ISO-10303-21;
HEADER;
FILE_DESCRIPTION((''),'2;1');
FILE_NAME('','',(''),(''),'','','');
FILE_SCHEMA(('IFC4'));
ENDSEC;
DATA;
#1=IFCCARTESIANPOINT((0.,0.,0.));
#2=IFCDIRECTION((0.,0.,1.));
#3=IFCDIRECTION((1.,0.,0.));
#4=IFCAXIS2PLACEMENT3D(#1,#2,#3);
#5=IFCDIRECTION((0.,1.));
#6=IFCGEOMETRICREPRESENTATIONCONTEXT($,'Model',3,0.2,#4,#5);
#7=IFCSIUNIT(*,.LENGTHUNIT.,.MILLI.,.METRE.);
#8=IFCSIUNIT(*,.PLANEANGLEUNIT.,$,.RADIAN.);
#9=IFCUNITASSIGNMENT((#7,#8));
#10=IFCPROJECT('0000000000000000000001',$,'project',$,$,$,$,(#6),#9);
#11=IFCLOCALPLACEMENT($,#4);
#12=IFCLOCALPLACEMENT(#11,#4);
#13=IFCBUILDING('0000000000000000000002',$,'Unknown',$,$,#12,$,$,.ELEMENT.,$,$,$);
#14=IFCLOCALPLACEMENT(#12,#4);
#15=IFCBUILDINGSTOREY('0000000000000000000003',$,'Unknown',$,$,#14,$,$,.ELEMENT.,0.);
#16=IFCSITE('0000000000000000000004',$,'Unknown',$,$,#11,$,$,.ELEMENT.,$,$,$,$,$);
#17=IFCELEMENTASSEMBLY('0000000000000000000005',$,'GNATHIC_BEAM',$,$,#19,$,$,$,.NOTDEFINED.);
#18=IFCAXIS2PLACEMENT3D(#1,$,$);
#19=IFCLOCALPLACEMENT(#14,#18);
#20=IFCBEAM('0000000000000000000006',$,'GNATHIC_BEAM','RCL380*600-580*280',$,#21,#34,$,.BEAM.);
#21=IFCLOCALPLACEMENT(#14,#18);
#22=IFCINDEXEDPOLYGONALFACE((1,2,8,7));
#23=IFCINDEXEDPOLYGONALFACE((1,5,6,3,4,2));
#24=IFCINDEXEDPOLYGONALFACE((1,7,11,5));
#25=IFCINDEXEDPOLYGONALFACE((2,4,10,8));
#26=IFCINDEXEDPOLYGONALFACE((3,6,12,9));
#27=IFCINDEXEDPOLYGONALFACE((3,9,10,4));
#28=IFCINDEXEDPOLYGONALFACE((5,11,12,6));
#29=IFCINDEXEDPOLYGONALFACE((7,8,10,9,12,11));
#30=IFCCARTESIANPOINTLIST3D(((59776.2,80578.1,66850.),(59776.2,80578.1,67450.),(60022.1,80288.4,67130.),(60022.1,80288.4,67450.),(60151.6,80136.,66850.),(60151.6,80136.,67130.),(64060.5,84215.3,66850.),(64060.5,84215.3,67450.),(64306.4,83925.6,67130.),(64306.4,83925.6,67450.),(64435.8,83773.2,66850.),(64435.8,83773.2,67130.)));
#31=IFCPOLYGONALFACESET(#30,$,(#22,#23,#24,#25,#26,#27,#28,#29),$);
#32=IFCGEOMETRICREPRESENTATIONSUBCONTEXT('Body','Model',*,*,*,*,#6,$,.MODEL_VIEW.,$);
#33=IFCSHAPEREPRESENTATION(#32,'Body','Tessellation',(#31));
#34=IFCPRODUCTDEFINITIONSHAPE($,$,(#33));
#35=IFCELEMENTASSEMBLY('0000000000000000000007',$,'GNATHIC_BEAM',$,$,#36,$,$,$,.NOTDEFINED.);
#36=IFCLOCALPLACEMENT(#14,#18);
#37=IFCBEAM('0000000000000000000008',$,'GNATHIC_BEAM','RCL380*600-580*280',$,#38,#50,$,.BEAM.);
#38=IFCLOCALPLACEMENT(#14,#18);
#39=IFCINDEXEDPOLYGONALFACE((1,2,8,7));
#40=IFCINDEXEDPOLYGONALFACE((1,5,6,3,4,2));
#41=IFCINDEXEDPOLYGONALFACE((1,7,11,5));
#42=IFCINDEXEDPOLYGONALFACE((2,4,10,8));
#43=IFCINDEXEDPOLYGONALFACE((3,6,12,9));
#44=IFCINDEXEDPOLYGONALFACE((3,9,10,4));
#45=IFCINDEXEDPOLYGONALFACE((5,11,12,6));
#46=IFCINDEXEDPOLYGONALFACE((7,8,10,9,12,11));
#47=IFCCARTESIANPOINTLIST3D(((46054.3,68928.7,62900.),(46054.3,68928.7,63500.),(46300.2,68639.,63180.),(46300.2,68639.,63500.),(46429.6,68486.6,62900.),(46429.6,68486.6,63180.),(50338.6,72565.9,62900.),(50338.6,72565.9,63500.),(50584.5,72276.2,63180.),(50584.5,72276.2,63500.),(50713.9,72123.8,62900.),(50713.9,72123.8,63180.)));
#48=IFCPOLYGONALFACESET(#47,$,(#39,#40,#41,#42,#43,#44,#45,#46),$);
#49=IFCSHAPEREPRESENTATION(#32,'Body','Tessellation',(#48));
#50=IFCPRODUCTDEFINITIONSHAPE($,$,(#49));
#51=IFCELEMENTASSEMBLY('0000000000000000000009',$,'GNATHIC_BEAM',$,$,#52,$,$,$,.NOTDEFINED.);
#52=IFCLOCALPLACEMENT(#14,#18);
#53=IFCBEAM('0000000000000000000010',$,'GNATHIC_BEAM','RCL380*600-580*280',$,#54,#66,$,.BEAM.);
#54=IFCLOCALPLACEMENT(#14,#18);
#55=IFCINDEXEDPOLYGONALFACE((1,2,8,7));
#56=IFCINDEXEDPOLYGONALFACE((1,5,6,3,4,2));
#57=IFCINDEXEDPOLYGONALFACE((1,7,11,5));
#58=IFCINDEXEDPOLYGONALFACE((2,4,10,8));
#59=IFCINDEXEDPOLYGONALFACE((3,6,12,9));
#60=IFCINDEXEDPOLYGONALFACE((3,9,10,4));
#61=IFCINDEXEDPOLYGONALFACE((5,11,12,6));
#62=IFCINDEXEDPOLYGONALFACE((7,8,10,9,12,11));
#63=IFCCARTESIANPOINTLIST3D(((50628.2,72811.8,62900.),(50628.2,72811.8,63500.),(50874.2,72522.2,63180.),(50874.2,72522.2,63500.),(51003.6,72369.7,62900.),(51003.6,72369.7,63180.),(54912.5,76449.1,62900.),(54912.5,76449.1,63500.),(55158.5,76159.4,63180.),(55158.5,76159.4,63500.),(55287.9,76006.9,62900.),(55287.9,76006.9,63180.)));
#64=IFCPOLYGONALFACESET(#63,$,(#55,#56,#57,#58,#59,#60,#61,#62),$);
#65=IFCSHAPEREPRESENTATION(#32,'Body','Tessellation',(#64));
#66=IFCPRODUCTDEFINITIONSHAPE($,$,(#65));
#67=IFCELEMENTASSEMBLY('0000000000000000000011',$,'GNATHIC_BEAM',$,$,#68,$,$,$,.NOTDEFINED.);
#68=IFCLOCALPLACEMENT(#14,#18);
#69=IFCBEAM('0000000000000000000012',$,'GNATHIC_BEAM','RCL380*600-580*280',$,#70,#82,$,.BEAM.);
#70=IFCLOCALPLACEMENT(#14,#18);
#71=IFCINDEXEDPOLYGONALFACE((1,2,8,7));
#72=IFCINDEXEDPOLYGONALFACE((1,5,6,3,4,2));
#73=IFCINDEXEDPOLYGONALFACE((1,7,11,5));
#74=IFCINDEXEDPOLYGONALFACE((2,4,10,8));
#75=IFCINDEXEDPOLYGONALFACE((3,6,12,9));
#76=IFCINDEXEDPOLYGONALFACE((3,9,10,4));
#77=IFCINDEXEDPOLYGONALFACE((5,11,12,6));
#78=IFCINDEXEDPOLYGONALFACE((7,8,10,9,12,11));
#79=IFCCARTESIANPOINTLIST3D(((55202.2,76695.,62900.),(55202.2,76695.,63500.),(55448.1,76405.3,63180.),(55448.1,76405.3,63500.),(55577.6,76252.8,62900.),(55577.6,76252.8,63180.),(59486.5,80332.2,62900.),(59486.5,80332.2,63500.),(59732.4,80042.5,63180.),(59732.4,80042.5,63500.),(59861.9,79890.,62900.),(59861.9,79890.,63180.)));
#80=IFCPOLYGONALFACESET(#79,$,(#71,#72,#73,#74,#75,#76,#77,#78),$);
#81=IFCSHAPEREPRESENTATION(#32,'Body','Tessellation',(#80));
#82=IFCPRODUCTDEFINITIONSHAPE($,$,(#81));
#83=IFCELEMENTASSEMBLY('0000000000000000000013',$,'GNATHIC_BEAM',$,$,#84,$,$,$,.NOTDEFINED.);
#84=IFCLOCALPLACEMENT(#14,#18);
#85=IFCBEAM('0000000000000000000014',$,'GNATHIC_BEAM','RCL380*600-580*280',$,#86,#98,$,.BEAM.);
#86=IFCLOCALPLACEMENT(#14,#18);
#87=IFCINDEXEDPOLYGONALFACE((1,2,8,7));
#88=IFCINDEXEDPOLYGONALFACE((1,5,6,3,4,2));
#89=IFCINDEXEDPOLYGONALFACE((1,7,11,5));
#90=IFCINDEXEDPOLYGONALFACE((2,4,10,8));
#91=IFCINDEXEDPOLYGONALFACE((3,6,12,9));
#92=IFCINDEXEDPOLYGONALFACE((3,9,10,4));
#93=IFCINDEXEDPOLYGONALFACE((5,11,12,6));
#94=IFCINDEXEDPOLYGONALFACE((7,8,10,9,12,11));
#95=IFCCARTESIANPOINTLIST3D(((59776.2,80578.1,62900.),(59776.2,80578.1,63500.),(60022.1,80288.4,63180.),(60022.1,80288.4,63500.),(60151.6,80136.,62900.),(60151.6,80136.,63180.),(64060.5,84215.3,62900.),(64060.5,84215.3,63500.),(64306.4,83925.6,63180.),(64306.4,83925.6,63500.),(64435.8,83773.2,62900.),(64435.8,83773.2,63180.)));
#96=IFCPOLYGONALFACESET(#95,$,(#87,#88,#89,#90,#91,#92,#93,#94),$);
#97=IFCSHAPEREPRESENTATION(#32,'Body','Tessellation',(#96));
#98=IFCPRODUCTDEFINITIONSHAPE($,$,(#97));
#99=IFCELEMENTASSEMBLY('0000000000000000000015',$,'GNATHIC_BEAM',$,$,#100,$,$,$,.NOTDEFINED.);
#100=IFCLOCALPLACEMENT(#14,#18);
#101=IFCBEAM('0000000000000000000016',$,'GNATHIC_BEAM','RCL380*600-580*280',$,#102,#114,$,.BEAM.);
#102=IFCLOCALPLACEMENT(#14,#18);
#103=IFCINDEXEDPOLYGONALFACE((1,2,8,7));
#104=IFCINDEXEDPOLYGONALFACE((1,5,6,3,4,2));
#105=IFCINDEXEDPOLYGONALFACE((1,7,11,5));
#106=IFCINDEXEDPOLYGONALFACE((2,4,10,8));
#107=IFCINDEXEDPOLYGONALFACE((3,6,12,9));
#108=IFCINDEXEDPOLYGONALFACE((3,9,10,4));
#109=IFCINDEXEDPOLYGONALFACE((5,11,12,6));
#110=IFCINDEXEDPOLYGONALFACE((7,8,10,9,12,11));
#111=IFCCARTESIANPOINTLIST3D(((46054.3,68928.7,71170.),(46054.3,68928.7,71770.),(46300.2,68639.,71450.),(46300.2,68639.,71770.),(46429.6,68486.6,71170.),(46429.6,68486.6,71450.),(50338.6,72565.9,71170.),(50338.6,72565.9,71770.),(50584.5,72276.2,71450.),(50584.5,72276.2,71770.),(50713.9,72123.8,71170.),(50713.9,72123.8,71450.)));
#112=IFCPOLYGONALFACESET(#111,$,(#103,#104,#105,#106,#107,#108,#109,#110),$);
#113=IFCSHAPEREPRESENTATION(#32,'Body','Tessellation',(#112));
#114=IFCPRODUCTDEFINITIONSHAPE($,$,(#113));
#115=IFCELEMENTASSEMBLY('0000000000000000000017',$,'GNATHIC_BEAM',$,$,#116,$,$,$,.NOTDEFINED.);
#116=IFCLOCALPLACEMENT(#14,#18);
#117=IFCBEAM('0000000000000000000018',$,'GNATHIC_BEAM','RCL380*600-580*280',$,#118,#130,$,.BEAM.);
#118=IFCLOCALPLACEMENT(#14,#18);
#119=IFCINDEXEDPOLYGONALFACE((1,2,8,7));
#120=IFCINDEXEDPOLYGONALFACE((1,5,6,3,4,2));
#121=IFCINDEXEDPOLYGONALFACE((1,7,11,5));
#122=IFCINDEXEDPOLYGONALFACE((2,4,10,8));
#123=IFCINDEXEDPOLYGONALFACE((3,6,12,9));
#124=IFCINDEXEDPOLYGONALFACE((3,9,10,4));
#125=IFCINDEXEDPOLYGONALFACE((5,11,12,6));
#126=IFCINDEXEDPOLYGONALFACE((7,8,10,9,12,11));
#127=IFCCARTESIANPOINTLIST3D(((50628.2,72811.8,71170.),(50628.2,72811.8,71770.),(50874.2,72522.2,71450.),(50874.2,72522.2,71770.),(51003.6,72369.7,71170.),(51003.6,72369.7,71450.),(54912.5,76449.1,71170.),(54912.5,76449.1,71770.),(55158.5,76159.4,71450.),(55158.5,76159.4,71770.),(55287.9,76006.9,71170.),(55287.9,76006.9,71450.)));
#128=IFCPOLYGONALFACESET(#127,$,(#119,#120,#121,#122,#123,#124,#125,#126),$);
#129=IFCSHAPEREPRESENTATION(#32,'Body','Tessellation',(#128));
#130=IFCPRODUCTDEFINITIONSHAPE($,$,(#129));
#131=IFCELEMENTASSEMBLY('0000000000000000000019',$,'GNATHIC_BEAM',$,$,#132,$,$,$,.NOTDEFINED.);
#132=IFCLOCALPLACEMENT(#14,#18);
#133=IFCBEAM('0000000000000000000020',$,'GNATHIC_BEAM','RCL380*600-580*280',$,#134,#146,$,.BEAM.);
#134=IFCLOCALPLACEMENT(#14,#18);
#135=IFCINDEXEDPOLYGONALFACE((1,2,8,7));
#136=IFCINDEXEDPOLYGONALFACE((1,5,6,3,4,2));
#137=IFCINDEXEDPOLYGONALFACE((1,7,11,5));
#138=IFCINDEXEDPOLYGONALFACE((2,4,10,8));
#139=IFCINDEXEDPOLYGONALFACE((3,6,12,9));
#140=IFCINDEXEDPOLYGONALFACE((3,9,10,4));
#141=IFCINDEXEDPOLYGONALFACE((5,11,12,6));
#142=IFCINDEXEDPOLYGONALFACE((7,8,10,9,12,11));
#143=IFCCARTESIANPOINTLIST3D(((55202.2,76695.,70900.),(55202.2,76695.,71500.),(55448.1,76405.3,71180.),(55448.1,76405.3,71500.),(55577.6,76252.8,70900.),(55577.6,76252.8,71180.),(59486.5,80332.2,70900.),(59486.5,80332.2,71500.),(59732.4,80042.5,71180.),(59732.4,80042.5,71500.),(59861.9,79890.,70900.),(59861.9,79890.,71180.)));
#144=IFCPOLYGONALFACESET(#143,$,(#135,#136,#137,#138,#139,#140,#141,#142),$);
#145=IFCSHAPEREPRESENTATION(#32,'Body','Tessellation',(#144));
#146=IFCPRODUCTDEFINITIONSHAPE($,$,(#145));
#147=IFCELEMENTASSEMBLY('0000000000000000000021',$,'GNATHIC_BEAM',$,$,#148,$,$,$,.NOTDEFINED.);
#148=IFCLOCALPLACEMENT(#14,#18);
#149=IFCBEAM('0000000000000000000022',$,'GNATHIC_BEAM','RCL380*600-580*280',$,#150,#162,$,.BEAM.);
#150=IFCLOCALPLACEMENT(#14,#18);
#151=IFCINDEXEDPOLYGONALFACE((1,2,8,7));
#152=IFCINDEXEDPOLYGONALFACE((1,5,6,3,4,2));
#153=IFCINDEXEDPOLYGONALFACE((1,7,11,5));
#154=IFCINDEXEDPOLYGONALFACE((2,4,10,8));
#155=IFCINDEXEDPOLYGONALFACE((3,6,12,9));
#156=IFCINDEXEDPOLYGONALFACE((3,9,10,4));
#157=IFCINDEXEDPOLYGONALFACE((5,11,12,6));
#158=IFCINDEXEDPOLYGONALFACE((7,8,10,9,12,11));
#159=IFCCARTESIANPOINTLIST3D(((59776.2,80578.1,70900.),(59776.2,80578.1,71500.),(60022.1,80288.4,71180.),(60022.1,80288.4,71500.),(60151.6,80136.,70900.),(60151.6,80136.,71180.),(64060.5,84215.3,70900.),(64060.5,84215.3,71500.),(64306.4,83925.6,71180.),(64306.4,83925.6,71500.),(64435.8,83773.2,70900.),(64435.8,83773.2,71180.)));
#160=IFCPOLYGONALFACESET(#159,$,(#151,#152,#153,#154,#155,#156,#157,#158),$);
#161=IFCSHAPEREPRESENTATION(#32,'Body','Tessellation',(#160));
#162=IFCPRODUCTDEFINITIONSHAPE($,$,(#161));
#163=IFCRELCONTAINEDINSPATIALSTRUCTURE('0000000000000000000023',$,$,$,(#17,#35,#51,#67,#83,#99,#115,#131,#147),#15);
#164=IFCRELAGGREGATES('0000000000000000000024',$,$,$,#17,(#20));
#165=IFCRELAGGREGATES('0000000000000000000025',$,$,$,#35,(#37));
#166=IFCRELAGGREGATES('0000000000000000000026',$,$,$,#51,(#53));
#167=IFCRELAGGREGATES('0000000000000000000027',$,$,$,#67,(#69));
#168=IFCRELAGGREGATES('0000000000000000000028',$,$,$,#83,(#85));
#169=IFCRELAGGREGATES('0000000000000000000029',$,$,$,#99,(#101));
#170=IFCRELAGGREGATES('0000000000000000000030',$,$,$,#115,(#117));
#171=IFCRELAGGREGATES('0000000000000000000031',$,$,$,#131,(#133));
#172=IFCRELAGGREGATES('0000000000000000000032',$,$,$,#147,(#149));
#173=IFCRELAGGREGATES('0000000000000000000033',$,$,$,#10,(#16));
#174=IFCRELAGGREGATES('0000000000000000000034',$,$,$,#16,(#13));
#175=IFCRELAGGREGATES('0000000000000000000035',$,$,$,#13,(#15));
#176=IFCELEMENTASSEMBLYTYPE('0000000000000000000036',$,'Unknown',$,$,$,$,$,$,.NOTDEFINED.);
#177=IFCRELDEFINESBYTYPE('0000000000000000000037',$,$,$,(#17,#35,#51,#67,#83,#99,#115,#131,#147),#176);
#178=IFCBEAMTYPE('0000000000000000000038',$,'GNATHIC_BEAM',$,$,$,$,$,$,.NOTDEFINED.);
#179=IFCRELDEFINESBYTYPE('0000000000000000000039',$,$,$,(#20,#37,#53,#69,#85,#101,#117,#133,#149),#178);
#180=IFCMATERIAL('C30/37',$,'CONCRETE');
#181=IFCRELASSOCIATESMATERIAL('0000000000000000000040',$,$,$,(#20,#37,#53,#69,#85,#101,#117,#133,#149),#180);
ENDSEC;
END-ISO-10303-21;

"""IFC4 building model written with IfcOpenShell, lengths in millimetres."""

from ifc_helpers import new_model, si_unit, direction, frame, origin_with_axes, place, context, subcontext, project, spatial, polyline, outline, extrude, material, material_profile, profile_set, profile_usage, type_object, element, aggregate, save


model = new_model("IFC4")

# Units and contexts
model_context = context("Model", 3, precision=0.2, world=origin_with_axes(), true_north=direction((0.0, 1.0)))
body_context = subcontext(model_context, "Body", "Model", "MODEL_VIEW")
ifc_project = project(units=[si_unit("LENGTHUNIT", "METRE", prefix="MILLI"), si_unit("PLANEANGLEUNIT", "RADIAN")], contexts=[model_context])

# Site, building, storey
site_placement = place(None, origin_with_axes())
site = spatial("IfcSite", under=ifc_project, at=site_placement, Name="Unknown", CompositionType="ELEMENT")
building_placement = place(site_placement, origin_with_axes())
building = spatial("IfcBuilding", under=site, at=building_placement, Name="Unknown", CompositionType="ELEMENT")
storey_placement = place(building_placement, origin_with_axes())
storey = spatial("IfcBuildingStorey", under=building, at=storey_placement, Name="Unknown", CompositionType="ELEMENT", Elevation=0.0)

# Shared definitions
element_assembly_type = type_object("IfcElementAssemblyType", Name="Unknown", PredefinedType="NOTDEFINED")

# Element assemblies, beams
ifc_material_1 = material(Name="C30/37", Category="CONCRETE")
ifc_material_profile_1 = material_profile(ifc_material_1, outline(polyline([(-190.0, -300.0), (390.0, -300.0), (390.0, -20.0), (190.0, -20.0), (190.0, 300.0), (-190.0, 300.0), (-190.0, -300.0)])), Name="RCL380*600-580*280")
ifc_profile_set_1 = profile_set([ifc_material_profile_1])
ifc_profile_usage_1 = profile_usage(ifc_profile_set_1, cardinal=2)
beam_type_1 = type_object("IfcBeamType", Name="GNATHIC_BEAM")
assembly_1_placement = place(storey_placement, frame((59899.1, 80433.3, 67150.0), z_axis=(0.64719, -0.762329, 0.0), x_axis=(0.762329, 0.64719, 0.0)))
assembly_1 = element("IfcElementAssembly", 1, at=assembly_1_placement, inside=storey, type_object=element_assembly_type, Name="GNATHIC_BEAM", PredefinedType="NOTDEFINED")
beam_1_placement = place(assembly_1_placement, origin_with_axes())
beam_1 = element("IfcBeam", 2, at=beam_1_placement, type_object=beam_type_1, material=ifc_profile_usage_1, Name="GNATHIC_BEAM", Description="RCL380*600-580*280", PredefinedType="BEAM", context=body_context, shape_type="SolidModel", body=[
    extrude(outline(polyline([(-190.0, -300.0), (390.0, -300.0), (390.0, -20.0), (190.0, -20.0), (190.0, 300.0), (-190.0, 300.0), (-190.0, -300.0)])), frame((0.0, 0.0, 0.0), z_axis=(-1.0, 0.0, 0.0), x_axis=(0.0, 0.0, 1.0)), (0.0, 0.0, -1.0), 5620.0),
])
aggregate(assembly_1, [beam_1])
assembly_2_placement = place(storey_placement, frame((46177.2, 68783.9, 63200.0), z_axis=(0.64719, -0.762329, 0.0), x_axis=(0.762329, 0.64719, 0.0)))
assembly_2 = element("IfcElementAssembly", 3, at=assembly_2_placement, inside=storey, type_object=element_assembly_type, Name="GNATHIC_BEAM", PredefinedType="NOTDEFINED")
beam_2_placement = place(assembly_2_placement, origin_with_axes())
beam_2 = element("IfcBeam", 4, at=beam_2_placement, type_object=beam_type_1, material=ifc_profile_usage_1, Name="GNATHIC_BEAM", Description="RCL380*600-580*280", PredefinedType="BEAM", context=body_context, shape_type="SolidModel", body=[
    extrude(outline(polyline([(-190.0, -300.0), (390.0, -300.0), (390.0, -20.0), (190.0, -20.0), (190.0, 300.0), (-190.0, 300.0), (-190.0, -300.0)])), frame((0.0, 0.0, 0.0), z_axis=(-1.0, 0.0, 0.0), x_axis=(0.0, 0.0, 1.0)), (0.0, 0.0, -1.0), 5620.0),
])
aggregate(assembly_2, [beam_2])
assembly_3_placement = place(storey_placement, frame((50751.2, 72667.0, 63200.0), z_axis=(0.64719, -0.762329, 0.0), x_axis=(0.762329, 0.64719, 0.0)))
assembly_3 = element("IfcElementAssembly", 5, at=assembly_3_placement, inside=storey, type_object=element_assembly_type, Name="GNATHIC_BEAM", PredefinedType="NOTDEFINED")
beam_3_placement = place(assembly_3_placement, origin_with_axes())
beam_3 = element("IfcBeam", 6, at=beam_3_placement, type_object=beam_type_1, material=ifc_profile_usage_1, Name="GNATHIC_BEAM", Description="RCL380*600-580*280", PredefinedType="BEAM", context=body_context, shape_type="SolidModel", body=[
    extrude(outline(polyline([(-190.0, -300.0), (390.0, -300.0), (390.0, -20.0), (190.0, -20.0), (190.0, 300.0), (-190.0, 300.0), (-190.0, -300.0)])), frame((0.0, 0.0, 0.0), z_axis=(-1.0, 0.0, 0.0), x_axis=(0.0, 0.0, 1.0)), (0.0, 0.0, -1.0), 5620.0),
])
aggregate(assembly_3, [beam_3])
assembly_4_placement = place(storey_placement, frame((55325.2, 76550.1, 63200.0), z_axis=(0.64719, -0.762329, 0.0), x_axis=(0.762329, 0.64719, 0.0)))
assembly_4 = element("IfcElementAssembly", 7, at=assembly_4_placement, inside=storey, type_object=element_assembly_type, Name="GNATHIC_BEAM", PredefinedType="NOTDEFINED")
beam_4_placement = place(assembly_4_placement, origin_with_axes())
beam_4 = element("IfcBeam", 8, at=beam_4_placement, type_object=beam_type_1, material=ifc_profile_usage_1, Name="GNATHIC_BEAM", Description="RCL380*600-580*280", PredefinedType="BEAM", context=body_context, shape_type="SolidModel", body=[
    extrude(outline(polyline([(-190.0, -300.0), (390.0, -300.0), (390.0, -20.0), (190.0, -20.0), (190.0, 300.0), (-190.0, 300.0), (-190.0, -300.0)])), frame((0.0, 0.0, 0.0), z_axis=(-1.0, 0.0, 0.0), x_axis=(0.0, 0.0, 1.0)), (0.0, 0.0, -1.0), 5620.0),
])
aggregate(assembly_4, [beam_4])
assembly_5_placement = place(storey_placement, frame((59899.1, 80433.3, 63200.0), z_axis=(0.64719, -0.762329, 0.0), x_axis=(0.762329, 0.64719, 0.0)))
assembly_5 = element("IfcElementAssembly", 9, at=assembly_5_placement, inside=storey, type_object=element_assembly_type, Name="GNATHIC_BEAM", PredefinedType="NOTDEFINED")
beam_5_placement = place(assembly_5_placement, origin_with_axes())
beam_5 = element("IfcBeam", 10, at=beam_5_placement, type_object=beam_type_1, material=ifc_profile_usage_1, Name="GNATHIC_BEAM", Description="RCL380*600-580*280", PredefinedType="BEAM", context=body_context, shape_type="SolidModel", body=[
    extrude(outline(polyline([(-190.0, -300.0), (390.0, -300.0), (390.0, -20.0), (190.0, -20.0), (190.0, 300.0), (-190.0, 300.0), (-190.0, -300.0)])), frame((0.0, 0.0, 0.0), z_axis=(-1.0, 0.0, 0.0), x_axis=(0.0, 0.0, 1.0)), (0.0, 0.0, -1.0), 5620.0),
])
aggregate(assembly_5, [beam_5])
assembly_6_placement = place(storey_placement, frame((46177.2, 68783.9, 71470.0), z_axis=(0.64719, -0.762329, 0.0), x_axis=(0.762329, 0.64719, 0.0)))
assembly_6 = element("IfcElementAssembly", 11, at=assembly_6_placement, inside=storey, type_object=element_assembly_type, Name="GNATHIC_BEAM", PredefinedType="NOTDEFINED")
beam_6_placement = place(assembly_6_placement, origin_with_axes())
beam_6 = element("IfcBeam", 12, at=beam_6_placement, type_object=beam_type_1, material=ifc_profile_usage_1, Name="GNATHIC_BEAM", Description="RCL380*600-580*280", PredefinedType="BEAM", context=body_context, shape_type="SolidModel", body=[
    extrude(outline(polyline([(-190.0, -300.0), (390.0, -300.0), (390.0, -20.0), (190.0, -20.0), (190.0, 300.0), (-190.0, 300.0), (-190.0, -300.0)])), frame((0.0, 0.0, 0.0), z_axis=(-1.0, 0.0, 0.0), x_axis=(0.0, 0.0, 1.0)), (0.0, 0.0, -1.0), 5620.0),
])
aggregate(assembly_6, [beam_6])
assembly_7_placement = place(storey_placement, frame((50751.2, 72667.0, 71470.0), z_axis=(0.64719, -0.762329, 0.0), x_axis=(0.762329, 0.64719, 0.0)))
assembly_7 = element("IfcElementAssembly", 13, at=assembly_7_placement, inside=storey, type_object=element_assembly_type, Name="GNATHIC_BEAM", PredefinedType="NOTDEFINED")
beam_7_placement = place(assembly_7_placement, origin_with_axes())
beam_7 = element("IfcBeam", 14, at=beam_7_placement, type_object=beam_type_1, material=ifc_profile_usage_1, Name="GNATHIC_BEAM", Description="RCL380*600-580*280", PredefinedType="BEAM", context=body_context, shape_type="SolidModel", body=[
    extrude(outline(polyline([(-190.0, -300.0), (390.0, -300.0), (390.0, -20.0), (190.0, -20.0), (190.0, 300.0), (-190.0, 300.0), (-190.0, -300.0)])), frame((0.0, 0.0, 0.0), z_axis=(-1.0, 0.0, 0.0), x_axis=(0.0, 0.0, 1.0)), (0.0, 0.0, -1.0), 5620.0),
])
aggregate(assembly_7, [beam_7])
assembly_8_placement = place(storey_placement, frame((55325.2, 76550.1, 71200.0), z_axis=(0.64719, -0.762329, 0.0), x_axis=(0.762329, 0.64719, 0.0)))
assembly_8 = element("IfcElementAssembly", 15, at=assembly_8_placement, inside=storey, type_object=element_assembly_type, Name="GNATHIC_BEAM", PredefinedType="NOTDEFINED")
beam_8_placement = place(assembly_8_placement, origin_with_axes())
beam_8 = element("IfcBeam", 16, at=beam_8_placement, type_object=beam_type_1, material=ifc_profile_usage_1, Name="GNATHIC_BEAM", Description="RCL380*600-580*280", PredefinedType="BEAM", context=body_context, shape_type="SolidModel", body=[
    extrude(outline(polyline([(-190.0, -300.0), (390.0, -300.0), (390.0, -20.0), (190.0, -20.0), (190.0, 300.0), (-190.0, 300.0), (-190.0, -300.0)])), frame((0.0, 0.0, 0.0), z_axis=(-1.0, 0.0, 0.0), x_axis=(0.0, 0.0, 1.0)), (0.0, 0.0, -1.0), 5620.0),
])
aggregate(assembly_8, [beam_8])
assembly_9_placement = place(storey_placement, frame((59899.1, 80433.3, 71200.0), z_axis=(0.64719, -0.762329, 0.0), x_axis=(0.762329, 0.64719, 0.0)))
assembly_9 = element("IfcElementAssembly", 17, at=assembly_9_placement, inside=storey, type_object=element_assembly_type, Name="GNATHIC_BEAM", PredefinedType="NOTDEFINED")
beam_9_placement = place(assembly_9_placement, origin_with_axes())
beam_9 = element("IfcBeam", 18, at=beam_9_placement, type_object=beam_type_1, material=ifc_profile_usage_1, Name="GNATHIC_BEAM", Description="RCL380*600-580*280", PredefinedType="BEAM", context=body_context, shape_type="SolidModel", body=[
    extrude(outline(polyline([(-190.0, -300.0), (390.0, -300.0), (390.0, -20.0), (190.0, -20.0), (190.0, 300.0), (-190.0, 300.0), (-190.0, -300.0)])), frame((0.0, 0.0, 0.0), z_axis=(-1.0, 0.0, 0.0), x_axis=(0.0, 0.0, 1.0)), (0.0, 0.0, -1.0), 5620.0),
])
aggregate(assembly_9, [beam_9])

save(model, "model.ifc")
